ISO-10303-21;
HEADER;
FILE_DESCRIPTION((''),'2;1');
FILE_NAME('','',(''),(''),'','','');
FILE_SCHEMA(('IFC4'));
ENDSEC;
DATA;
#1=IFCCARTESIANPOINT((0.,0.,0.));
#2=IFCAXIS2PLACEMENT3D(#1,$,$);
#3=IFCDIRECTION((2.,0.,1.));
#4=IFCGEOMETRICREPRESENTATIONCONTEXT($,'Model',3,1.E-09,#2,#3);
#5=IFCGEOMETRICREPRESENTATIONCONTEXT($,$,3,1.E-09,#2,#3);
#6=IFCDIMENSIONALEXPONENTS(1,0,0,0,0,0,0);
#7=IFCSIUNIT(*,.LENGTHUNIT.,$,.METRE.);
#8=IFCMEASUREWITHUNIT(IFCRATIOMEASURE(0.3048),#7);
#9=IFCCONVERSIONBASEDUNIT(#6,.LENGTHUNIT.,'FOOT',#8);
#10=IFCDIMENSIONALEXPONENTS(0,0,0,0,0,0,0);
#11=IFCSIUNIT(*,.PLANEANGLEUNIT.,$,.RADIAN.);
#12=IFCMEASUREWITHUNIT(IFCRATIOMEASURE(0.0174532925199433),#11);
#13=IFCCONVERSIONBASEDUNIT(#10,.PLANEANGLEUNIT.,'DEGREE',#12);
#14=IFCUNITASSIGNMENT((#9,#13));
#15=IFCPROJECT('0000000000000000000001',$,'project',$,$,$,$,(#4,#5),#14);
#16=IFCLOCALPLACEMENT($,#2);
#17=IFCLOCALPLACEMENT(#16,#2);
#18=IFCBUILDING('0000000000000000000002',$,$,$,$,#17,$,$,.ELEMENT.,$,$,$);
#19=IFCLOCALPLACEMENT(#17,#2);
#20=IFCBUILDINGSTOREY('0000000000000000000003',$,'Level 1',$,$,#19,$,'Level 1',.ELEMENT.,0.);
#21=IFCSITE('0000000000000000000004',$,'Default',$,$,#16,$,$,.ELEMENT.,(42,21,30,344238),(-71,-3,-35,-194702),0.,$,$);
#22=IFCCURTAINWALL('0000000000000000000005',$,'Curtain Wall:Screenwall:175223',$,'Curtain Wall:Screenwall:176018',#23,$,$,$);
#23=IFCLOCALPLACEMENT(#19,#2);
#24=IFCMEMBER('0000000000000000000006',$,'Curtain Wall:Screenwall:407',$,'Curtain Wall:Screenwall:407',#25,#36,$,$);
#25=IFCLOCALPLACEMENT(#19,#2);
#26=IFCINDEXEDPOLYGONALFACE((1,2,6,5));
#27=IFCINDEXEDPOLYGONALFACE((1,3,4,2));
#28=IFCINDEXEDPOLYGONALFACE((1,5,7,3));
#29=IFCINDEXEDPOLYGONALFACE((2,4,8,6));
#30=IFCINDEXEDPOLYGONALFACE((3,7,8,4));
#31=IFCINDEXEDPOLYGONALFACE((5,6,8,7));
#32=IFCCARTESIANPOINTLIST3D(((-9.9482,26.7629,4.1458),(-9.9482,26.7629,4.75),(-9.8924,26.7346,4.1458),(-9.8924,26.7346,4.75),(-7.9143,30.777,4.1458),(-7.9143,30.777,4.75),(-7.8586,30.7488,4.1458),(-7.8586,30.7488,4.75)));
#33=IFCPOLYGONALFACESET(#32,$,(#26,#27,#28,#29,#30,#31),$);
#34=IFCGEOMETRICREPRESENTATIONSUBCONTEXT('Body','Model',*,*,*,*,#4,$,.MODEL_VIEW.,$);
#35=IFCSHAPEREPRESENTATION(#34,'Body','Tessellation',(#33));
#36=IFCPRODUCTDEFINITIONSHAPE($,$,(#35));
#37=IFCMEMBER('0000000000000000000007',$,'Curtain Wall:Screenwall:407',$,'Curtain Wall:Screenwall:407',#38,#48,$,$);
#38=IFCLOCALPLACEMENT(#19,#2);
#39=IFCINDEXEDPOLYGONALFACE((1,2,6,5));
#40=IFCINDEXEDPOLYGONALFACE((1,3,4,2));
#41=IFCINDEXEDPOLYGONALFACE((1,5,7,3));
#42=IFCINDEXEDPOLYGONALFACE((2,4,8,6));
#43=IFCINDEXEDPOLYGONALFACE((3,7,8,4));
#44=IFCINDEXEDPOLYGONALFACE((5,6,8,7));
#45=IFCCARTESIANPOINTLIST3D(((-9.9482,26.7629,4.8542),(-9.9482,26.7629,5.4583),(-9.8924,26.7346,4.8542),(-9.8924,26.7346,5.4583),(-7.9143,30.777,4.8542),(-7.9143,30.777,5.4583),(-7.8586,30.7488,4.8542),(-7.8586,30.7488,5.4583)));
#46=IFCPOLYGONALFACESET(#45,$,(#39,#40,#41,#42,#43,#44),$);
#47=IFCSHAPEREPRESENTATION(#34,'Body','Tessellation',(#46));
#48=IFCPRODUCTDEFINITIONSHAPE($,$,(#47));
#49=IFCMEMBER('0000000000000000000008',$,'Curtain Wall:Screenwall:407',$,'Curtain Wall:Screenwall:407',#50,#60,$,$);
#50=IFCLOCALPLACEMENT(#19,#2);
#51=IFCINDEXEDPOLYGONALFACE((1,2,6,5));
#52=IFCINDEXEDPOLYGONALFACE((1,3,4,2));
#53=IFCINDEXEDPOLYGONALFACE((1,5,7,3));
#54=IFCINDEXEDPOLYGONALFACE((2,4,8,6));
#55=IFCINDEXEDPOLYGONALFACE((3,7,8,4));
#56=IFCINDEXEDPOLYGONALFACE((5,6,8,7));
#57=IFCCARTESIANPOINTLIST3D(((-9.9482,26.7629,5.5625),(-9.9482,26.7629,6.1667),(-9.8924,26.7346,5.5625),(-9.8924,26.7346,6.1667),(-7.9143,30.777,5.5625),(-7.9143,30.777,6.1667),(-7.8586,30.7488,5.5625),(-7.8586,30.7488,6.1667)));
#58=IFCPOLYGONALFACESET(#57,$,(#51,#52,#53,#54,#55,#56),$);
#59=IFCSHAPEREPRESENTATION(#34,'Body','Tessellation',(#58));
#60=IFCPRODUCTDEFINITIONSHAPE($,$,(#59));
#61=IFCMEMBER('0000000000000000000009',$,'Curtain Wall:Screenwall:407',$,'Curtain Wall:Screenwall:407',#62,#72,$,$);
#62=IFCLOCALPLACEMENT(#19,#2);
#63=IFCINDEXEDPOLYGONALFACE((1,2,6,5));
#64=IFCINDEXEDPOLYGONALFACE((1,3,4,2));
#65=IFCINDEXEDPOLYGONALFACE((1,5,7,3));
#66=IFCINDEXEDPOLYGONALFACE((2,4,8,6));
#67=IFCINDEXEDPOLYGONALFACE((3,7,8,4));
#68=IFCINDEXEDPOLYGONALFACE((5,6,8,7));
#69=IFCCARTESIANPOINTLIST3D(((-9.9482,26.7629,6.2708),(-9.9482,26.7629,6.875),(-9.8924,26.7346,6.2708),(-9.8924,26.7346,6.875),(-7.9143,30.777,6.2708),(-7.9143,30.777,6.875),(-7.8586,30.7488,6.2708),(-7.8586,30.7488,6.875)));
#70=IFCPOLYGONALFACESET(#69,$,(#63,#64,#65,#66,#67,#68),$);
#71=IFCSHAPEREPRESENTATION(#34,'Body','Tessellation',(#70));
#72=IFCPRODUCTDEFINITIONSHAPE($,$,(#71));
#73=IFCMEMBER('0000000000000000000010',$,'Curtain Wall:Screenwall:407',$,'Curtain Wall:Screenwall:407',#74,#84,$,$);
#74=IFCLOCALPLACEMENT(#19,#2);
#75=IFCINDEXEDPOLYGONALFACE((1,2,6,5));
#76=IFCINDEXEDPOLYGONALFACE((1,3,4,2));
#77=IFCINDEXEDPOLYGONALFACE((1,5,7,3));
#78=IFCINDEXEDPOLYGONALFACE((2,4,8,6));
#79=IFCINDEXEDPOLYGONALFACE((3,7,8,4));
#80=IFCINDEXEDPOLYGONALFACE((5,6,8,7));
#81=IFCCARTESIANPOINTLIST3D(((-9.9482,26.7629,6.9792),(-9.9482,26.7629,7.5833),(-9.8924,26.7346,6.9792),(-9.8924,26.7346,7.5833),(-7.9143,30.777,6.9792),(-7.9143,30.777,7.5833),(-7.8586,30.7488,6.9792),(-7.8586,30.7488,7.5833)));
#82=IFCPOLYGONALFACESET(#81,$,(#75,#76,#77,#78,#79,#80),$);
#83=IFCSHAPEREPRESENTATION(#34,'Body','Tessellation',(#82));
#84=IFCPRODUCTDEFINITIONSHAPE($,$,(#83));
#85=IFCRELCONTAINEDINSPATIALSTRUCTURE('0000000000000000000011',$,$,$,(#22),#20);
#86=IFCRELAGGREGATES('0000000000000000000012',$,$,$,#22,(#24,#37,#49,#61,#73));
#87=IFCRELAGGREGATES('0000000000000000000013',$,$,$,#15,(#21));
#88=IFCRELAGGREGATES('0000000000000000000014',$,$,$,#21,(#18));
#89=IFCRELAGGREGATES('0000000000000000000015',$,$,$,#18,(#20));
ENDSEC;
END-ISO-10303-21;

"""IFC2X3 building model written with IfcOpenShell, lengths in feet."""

from ifc_helpers import new_model, entity, si_unit, converted_unit, direction, frame, frame_2d, origin, origin_2d_with_axis, place, context, subcontext, project, spatial, rectangle, extrude, element, aggregate, save


model = new_model("IFC2X3")

# Units and contexts
model_context = context("Model", 3, precision=1e-09, world=origin(), true_north=direction((2.0, 0.0, 1.0)))
context_of_model = context(None, 3, precision=1e-09, world=origin(), true_north=direction((2.0, 0.0, 1.0)))
body_context = subcontext(model_context, "Body", "Model", "MODEL_VIEW")
ifc_project = project(units=[converted_unit("LENGTHUNIT", "FOOT", entity("IfcRatioMeasure", 0.3048), si_unit("LENGTHUNIT", "METRE"), dimensions=[1, 0, 0, 0, 0, 0, 0]), converted_unit("PLANEANGLEUNIT", "DEGREE", entity("IfcRatioMeasure", 0.0174532925199433), si_unit("PLANEANGLEUNIT", "RADIAN"), dimensions=[0, 0, 0, 0, 0, 0, 0])], contexts=[model_context, context_of_model])

# Site, building, storey
site_placement = place(None, origin())
site = spatial("IfcSite", under=ifc_project, at=site_placement, Name="Default", CompositionType="ELEMENT", RefLatitude=(42, 21, 30, 344238), RefLongitude=(-71, -3, -35, -194702), RefElevation=0.0)
building_placement = place(site_placement, origin())
building = spatial("IfcBuilding", under=site, at=building_placement, CompositionType="ELEMENT")
storey_placement = place(building_placement, origin())
storey = spatial("IfcBuildingStorey", under=building, at=storey_placement, Name="Level 1", LongName="Level 1", CompositionType="ELEMENT", Elevation=0.0)

# Curtain wall, members
curtain_wall_1_placement = place(storey_placement, origin())
curtain_wall_1 = element("IfcCurtainWall", 1, at=curtain_wall_1_placement, inside=storey, Name="Curtain Wall:Screenwall:175223", ObjectType="Curtain Wall:Screenwall:176018")
member_1_placement = place(curtain_wall_1_placement, frame((-9.9482, 26.7346, 4.1458)))
member_1 = element("IfcMember", 2, at=member_1_placement, Name="Curtain Wall:Screenwall:407", ObjectType="Curtain Wall:Screenwall:407", context=body_context, shape_type="SweptSolid", body=[
    extrude(rectangle(XDim=4.5, YDim=0.0625, at=origin_2d_with_axis()), frame((1.0448, 2.0212, 0.0), z_axis=(0.0, 0.0, 1.0), x_axis=(-0.451968, -0.892034, 0.0)), (0.0, 0.0, 1.0), 0.6042),
])
member_2_placement = place(curtain_wall_1_placement, frame((-9.9482, 26.7346, 4.8542)))
member_2 = element("IfcMember", 3, at=member_2_placement, Name="Curtain Wall:Screenwall:407", ObjectType="Curtain Wall:Screenwall:407", context=body_context, shape_type="SweptSolid", body=[
    extrude(rectangle(XDim=4.5, YDim=0.0625, at=origin_2d_with_axis()), frame((1.0448, 2.0212, 0.0), z_axis=(0.0, 0.0, 1.0), x_axis=(-0.451968, -0.892034, 0.0)), (0.0, 0.0, 1.0), 0.6042),
])
member_3_placement = place(curtain_wall_1_placement, frame((-9.9482, 26.7346, 5.5625)))
member_3 = element("IfcMember", 4, at=member_3_placement, Name="Curtain Wall:Screenwall:407", ObjectType="Curtain Wall:Screenwall:407", context=body_context, shape_type="SweptSolid", body=[
    extrude(rectangle(XDim=4.5, YDim=0.0625, at=frame_2d((0.0, 0.0), x_axis=(1.0, 0.0))), frame((1.0448, 2.0212, 0.0), z_axis=(0.0, 0.0, 1.0), x_axis=(-0.451968, -0.892034, 0.0)), (0.0, 0.0, 1.0), 0.6042),
])
member_4_placement = place(curtain_wall_1_placement, frame((-9.9482, 26.7346, 6.2708)))
member_4 = element("IfcMember", 5, at=member_4_placement, Name="Curtain Wall:Screenwall:407", ObjectType="Curtain Wall:Screenwall:407", context=body_context, shape_type="SweptSolid", body=[
    extrude(rectangle(XDim=4.5, YDim=0.0625, at=origin_2d_with_axis()), frame((1.0448, 2.0212, 0.0), z_axis=(0.0, 0.0, 1.0), x_axis=(-0.451968, -0.892034, 0.0)), (0.0, 0.0, 1.0), 0.6042),
])
member_5_placement = place(curtain_wall_1_placement, frame((-9.9482, 26.7346, 6.9792)))
member_5 = element("IfcMember", 6, at=member_5_placement, Name="Curtain Wall:Screenwall:407", ObjectType="Curtain Wall:Screenwall:407", context=body_context, shape_type="SweptSolid", body=[
    extrude(rectangle(XDim=4.5, YDim=0.0625, at=origin_2d_with_axis()), frame((1.0448, 2.0212, 0.0), z_axis=(0.0, 0.0, 1.0), x_axis=(-0.451968, -0.892034, 0.0)), (0.0, 0.0, 1.0), 0.6042),
])
aggregate(curtain_wall_1, [member_1, member_2, member_3, member_4, member_5])

save(model, "model.ifc")
